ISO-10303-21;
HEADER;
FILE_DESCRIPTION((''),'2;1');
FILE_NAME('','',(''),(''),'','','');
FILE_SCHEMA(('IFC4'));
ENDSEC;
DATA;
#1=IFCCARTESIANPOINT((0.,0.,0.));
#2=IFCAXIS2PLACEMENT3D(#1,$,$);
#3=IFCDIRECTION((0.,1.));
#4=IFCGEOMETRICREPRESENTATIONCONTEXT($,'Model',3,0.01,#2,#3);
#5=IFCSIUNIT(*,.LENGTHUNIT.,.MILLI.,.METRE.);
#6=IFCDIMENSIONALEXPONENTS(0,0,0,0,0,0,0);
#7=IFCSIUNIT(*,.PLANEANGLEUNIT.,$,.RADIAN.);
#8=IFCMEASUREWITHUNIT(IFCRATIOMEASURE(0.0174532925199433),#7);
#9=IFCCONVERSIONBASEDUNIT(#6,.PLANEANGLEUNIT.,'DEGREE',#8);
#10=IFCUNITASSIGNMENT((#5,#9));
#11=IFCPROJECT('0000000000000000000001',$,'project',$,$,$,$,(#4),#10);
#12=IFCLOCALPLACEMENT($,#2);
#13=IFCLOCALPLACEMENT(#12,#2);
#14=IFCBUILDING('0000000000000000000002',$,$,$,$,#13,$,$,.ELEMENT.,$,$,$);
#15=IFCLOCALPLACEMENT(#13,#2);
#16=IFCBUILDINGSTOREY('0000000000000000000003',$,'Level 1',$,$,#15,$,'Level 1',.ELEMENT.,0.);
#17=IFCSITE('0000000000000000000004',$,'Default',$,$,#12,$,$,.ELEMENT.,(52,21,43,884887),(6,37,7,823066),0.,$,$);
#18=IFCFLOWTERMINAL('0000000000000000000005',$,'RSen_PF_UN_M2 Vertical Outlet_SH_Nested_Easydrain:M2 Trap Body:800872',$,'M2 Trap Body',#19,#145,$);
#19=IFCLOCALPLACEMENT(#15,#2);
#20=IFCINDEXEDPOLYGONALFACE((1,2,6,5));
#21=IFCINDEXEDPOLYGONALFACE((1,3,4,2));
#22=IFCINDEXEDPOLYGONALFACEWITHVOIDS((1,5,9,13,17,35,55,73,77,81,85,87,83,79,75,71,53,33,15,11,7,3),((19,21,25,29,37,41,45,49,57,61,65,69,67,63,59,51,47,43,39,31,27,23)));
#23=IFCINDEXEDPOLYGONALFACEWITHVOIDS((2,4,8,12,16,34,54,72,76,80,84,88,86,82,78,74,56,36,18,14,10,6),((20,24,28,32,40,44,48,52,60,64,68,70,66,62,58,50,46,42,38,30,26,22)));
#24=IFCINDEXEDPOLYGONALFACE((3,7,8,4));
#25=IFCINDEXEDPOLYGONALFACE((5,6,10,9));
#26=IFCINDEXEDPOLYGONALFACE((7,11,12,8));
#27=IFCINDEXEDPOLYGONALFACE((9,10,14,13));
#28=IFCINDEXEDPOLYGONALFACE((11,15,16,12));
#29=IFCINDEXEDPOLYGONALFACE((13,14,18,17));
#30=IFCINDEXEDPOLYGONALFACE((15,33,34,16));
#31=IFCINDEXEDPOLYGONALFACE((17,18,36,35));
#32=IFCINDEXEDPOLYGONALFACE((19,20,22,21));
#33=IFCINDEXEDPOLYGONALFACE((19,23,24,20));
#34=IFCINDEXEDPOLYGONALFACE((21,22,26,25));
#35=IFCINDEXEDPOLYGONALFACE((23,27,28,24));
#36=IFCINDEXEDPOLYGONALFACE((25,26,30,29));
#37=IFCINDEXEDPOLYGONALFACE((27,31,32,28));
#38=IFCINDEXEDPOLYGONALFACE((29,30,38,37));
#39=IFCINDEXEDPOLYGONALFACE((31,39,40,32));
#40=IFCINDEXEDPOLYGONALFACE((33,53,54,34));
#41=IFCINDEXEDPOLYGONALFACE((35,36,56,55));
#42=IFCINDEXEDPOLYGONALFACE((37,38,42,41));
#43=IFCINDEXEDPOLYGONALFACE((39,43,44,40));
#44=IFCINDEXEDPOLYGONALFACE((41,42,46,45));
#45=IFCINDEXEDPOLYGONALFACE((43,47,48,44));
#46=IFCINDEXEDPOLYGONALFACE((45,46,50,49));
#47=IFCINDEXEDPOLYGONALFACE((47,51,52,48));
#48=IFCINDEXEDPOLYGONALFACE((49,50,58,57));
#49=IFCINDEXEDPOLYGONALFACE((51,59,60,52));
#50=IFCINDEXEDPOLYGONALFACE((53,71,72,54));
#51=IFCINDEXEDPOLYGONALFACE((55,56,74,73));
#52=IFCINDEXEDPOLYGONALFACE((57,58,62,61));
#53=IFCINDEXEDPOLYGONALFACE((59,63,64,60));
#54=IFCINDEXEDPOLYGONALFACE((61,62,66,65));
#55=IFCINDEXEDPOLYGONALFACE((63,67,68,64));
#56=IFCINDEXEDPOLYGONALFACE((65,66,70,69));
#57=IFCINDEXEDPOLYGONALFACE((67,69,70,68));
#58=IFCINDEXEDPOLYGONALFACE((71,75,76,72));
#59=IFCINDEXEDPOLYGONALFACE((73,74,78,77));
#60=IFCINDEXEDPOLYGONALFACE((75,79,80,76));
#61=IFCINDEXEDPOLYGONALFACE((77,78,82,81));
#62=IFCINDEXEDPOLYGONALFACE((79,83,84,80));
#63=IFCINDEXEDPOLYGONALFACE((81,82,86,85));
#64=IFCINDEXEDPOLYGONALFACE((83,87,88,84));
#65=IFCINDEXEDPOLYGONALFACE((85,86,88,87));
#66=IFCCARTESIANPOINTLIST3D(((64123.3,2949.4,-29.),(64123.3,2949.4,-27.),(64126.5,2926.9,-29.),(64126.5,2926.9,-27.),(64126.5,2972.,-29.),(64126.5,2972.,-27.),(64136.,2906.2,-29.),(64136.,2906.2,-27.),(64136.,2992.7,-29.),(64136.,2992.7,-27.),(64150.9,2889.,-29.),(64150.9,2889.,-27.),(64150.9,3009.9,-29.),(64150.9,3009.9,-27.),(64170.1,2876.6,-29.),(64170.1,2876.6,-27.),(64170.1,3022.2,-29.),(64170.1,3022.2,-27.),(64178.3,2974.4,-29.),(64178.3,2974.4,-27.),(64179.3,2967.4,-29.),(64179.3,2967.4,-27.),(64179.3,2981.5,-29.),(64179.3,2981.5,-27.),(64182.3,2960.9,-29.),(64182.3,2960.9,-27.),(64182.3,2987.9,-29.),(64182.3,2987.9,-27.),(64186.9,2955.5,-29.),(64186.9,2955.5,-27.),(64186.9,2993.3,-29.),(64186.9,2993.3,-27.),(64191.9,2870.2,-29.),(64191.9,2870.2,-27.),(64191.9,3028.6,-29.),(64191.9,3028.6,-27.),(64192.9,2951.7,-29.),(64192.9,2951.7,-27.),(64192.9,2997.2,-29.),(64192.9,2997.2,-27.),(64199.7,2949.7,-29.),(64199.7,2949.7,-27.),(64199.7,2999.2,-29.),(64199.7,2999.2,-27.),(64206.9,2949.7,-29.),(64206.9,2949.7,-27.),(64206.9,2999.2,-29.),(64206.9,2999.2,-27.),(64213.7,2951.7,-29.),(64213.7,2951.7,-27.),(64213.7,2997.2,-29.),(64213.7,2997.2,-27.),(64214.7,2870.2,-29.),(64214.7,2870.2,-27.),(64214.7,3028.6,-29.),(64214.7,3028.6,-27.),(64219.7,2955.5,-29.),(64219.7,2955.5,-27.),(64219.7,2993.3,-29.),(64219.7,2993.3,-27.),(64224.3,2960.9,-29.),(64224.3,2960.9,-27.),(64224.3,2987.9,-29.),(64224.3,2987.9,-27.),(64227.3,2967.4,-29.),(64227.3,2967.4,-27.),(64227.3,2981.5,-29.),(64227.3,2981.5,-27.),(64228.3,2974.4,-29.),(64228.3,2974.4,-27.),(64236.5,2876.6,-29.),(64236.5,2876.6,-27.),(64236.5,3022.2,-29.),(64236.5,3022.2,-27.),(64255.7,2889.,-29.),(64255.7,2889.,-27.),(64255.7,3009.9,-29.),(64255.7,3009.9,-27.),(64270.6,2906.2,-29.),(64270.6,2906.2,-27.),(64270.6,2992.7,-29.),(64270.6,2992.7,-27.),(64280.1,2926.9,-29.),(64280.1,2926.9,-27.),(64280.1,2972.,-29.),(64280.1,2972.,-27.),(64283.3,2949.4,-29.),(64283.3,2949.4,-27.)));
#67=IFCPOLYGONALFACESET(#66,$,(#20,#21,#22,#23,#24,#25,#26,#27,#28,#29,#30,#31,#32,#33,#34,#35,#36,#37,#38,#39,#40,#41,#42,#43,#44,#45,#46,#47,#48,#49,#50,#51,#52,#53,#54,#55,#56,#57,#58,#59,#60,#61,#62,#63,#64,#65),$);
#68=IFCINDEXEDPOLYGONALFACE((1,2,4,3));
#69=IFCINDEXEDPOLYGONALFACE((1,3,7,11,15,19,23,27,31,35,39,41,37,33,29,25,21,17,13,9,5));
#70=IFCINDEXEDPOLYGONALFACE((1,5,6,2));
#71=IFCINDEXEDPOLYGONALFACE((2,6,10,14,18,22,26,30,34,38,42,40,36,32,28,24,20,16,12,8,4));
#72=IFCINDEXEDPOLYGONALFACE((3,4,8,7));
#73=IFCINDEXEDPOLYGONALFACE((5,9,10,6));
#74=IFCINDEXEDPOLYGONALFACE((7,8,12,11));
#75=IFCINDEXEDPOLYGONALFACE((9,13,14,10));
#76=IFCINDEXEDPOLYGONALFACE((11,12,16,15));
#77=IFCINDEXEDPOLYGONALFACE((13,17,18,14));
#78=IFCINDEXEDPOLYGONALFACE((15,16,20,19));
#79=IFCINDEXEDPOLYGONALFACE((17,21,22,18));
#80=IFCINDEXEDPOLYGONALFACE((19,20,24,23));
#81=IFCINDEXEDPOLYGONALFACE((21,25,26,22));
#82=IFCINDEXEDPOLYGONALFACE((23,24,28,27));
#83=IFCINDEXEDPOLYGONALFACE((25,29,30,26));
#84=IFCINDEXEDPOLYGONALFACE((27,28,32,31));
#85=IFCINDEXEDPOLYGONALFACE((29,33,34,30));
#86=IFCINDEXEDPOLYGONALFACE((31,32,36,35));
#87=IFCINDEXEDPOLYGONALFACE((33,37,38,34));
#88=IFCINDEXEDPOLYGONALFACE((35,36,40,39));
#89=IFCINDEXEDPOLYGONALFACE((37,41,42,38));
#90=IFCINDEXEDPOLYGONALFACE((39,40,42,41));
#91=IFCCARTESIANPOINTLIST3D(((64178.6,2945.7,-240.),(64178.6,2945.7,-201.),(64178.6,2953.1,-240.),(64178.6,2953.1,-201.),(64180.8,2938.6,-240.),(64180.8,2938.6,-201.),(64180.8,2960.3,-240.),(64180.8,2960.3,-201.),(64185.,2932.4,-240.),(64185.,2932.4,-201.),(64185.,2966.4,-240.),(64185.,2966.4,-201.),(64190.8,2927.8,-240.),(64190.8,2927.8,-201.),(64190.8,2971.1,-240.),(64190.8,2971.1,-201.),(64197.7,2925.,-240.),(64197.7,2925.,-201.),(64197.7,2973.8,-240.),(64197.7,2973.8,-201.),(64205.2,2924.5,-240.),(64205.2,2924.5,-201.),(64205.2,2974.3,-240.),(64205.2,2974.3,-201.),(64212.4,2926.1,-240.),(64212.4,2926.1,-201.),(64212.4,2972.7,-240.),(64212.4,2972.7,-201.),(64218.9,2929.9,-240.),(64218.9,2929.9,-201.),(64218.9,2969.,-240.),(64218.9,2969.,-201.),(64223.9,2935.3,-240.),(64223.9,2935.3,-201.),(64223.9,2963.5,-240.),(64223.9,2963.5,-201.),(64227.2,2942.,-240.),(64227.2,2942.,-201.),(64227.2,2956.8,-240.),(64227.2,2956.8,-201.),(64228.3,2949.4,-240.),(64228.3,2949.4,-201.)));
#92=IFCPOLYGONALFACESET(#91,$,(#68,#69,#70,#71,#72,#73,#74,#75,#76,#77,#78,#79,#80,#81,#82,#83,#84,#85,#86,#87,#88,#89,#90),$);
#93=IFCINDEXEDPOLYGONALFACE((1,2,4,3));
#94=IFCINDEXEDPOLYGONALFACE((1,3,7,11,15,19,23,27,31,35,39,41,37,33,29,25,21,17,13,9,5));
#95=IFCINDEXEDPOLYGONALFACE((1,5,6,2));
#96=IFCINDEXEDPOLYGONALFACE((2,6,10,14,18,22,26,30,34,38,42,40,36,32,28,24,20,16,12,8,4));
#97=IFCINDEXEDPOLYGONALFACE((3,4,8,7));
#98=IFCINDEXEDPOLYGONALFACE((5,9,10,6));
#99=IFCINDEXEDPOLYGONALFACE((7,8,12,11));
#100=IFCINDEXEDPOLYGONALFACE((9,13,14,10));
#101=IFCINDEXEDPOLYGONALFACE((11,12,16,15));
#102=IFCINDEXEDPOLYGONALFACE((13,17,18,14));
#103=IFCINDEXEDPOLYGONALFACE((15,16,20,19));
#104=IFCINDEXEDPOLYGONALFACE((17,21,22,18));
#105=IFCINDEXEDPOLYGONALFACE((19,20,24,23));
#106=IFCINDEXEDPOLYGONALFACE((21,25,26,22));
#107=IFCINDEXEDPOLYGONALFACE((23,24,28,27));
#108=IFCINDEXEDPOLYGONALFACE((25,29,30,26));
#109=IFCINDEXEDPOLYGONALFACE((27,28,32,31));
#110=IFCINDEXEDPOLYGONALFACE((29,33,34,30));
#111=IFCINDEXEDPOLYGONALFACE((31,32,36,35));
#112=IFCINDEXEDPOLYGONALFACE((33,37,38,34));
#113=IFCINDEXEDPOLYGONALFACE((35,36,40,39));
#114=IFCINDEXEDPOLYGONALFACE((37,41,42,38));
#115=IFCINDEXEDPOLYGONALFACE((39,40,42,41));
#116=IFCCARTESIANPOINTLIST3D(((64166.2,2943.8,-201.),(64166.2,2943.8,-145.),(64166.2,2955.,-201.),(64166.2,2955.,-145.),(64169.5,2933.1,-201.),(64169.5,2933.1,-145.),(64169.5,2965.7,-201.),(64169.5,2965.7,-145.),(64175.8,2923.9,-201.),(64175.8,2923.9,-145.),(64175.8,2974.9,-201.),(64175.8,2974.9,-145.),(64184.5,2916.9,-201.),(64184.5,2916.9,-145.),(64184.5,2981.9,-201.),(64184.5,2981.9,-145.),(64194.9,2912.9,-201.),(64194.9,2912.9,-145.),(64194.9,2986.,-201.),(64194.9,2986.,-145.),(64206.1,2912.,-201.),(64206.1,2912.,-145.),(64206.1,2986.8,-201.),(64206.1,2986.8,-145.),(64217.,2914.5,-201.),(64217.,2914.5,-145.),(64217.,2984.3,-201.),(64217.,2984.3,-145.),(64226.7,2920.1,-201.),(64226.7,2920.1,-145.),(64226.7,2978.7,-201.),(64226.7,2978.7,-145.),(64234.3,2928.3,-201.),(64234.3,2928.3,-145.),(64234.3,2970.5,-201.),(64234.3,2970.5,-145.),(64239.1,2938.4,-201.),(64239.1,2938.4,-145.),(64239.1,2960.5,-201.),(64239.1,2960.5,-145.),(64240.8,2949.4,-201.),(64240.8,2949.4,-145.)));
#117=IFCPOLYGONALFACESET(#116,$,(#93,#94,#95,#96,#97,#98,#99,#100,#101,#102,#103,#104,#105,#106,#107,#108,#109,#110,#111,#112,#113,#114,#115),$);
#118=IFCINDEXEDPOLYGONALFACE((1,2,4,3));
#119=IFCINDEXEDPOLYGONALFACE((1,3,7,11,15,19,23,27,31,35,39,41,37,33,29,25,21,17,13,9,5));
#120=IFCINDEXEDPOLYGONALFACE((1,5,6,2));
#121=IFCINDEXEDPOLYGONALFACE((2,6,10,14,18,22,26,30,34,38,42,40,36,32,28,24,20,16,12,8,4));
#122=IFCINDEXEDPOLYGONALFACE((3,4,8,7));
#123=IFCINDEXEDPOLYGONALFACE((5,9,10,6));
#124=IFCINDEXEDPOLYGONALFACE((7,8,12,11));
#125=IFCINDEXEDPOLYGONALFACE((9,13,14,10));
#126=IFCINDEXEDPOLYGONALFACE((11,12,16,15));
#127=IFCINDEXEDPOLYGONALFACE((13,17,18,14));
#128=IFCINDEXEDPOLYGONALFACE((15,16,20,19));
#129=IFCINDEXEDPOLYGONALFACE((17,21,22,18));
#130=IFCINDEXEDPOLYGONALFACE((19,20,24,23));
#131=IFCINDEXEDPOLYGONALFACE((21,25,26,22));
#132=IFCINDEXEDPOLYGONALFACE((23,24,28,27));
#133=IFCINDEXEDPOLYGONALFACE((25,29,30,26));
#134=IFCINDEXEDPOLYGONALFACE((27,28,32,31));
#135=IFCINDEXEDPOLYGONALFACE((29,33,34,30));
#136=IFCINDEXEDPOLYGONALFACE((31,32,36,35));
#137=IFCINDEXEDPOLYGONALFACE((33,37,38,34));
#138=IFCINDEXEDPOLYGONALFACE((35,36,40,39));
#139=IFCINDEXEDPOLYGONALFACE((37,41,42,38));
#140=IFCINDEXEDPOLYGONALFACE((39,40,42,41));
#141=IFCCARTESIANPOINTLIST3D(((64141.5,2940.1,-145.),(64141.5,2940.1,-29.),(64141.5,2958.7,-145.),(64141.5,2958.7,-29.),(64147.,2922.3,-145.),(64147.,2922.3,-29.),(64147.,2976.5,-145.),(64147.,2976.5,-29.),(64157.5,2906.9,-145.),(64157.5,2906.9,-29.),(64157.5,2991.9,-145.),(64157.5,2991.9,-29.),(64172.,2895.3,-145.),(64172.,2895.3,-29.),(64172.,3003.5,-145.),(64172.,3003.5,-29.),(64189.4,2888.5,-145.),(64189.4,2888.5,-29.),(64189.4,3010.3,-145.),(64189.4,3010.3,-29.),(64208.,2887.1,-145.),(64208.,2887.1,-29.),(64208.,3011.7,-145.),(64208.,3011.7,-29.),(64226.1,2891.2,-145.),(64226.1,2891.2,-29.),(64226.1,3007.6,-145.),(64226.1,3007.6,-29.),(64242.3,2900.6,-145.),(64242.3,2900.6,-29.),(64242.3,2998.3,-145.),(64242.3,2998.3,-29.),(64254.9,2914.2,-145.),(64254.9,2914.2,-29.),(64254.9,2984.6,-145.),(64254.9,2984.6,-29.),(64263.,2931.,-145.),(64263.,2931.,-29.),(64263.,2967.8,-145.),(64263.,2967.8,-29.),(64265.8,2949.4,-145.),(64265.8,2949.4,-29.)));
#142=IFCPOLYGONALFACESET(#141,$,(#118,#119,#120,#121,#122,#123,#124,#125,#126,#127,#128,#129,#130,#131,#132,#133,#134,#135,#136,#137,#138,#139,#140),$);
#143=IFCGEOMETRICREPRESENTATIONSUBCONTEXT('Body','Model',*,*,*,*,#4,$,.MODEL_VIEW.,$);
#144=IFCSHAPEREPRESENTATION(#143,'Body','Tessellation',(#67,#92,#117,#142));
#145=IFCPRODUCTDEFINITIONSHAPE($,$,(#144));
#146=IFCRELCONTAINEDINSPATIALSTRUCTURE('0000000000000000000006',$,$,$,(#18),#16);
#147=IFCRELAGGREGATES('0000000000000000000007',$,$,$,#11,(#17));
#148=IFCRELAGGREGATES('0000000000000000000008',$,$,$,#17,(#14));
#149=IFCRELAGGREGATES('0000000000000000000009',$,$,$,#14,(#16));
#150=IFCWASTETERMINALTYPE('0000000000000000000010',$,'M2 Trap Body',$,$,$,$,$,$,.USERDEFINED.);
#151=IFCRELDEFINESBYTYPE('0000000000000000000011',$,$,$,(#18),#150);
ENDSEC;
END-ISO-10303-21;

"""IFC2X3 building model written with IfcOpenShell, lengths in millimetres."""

from ifc_helpers import new_model, entity, si_unit, converted_unit, direction, frame, frame_2d, origin, origin_2d_with_axis, place, context, subcontext, project, spatial, circle_curve, parameter, trimmed, segment, composite_curve, circle, outline, extrude, source, transform, mapped, type_object, type_shapes, element, save


model = new_model("IFC2X3")

# Units and contexts
model_context = context("Model", 3, precision=0.01, world=origin(), true_north=direction((0.0, 1.0)))
body_context = subcontext(model_context, "Body", "Model", "MODEL_VIEW")
ifc_project = project(units=[si_unit("LENGTHUNIT", "METRE", prefix="MILLI"), converted_unit("PLANEANGLEUNIT", "DEGREE", entity("IfcRatioMeasure", 0.0174532925199433), si_unit("PLANEANGLEUNIT", "RADIAN"), dimensions=[0, 0, 0, 0, 0, 0, 0])], contexts=[model_context])

# Site, building, storey
site_placement = place(None, origin())
site = spatial("IfcSite", under=ifc_project, at=site_placement, Name="Default", CompositionType="ELEMENT", RefLatitude=(52, 21, 43, 884887), RefLongitude=(6, 37, 7, 823066), RefElevation=0.0)
building_placement = place(site_placement, origin())
building = spatial("IfcBuilding", under=site, at=building_placement, CompositionType="ELEMENT")
storey_placement = place(building_placement, origin())
storey = spatial("IfcBuildingStorey", under=building, at=storey_placement, Name="Level 1", LongName="Level 1", CompositionType="ELEMENT", Elevation=0.0)

# Flow terminal
waste_terminal_type_1 = type_object("IfcWasteTerminalType", Name="M2 Trap Body", PredefinedType="USERDEFINED")
shared_shape_1 = source(origin(), body_context, "Body", "SweptSolid", [
    extrude(outline(composite_curve([segment(trimmed(circle_curve(origin_2d_with_axis(), 80.0), [parameter(0.0)], [parameter(180.0)], True, "PARAMETER"), True, "CONTINUOUS"), segment(trimmed(circle_curve(origin_2d_with_axis(), 80.0), [parameter(180.0)], [parameter(360.0)], True, "PARAMETER"), True, "CONTINUOUS")], self_intersect=False), holes=[composite_curve([segment(trimmed(circle_curve(frame_2d((0.0, 25.0), x_axis=(1.0, 0.0)), 25.0), [parameter(180.0)], [parameter(360.0)], True, "PARAMETER"), False, "CONTINUOUS"), segment(trimmed(circle_curve(frame_2d((0.0, 25.0), x_axis=(1.0, 0.0)), 25.0), [parameter(0.0)], [parameter(180.0)], True, "PARAMETER"), False, "CONTINUOUS")], self_intersect=False)]), frame((0.0, -25.0, -2.0)), (0.0, 0.0, 1.0), 2.0),
    extrude(circle(Radius=25.0, at=frame_2d((0.0, 0.0), x_axis=(1.0, 0.0))), frame((0.0, -25.0, -213.0)), (0.0, 0.0, 1.0), 39.0),
    extrude(circle(Radius=37.5, at=frame_2d((0.0, 0.0), x_axis=(1.0, 0.0))), frame((0.0, -25.0, -174.0)), (0.0, 0.0, 1.0), 56.0),
    extrude(circle(Radius=62.5, at=frame_2d((0.0, 0.0), x_axis=(1.0, 0.0))), frame((0.0, -25.0, -118.0)), (0.0, 0.0, 1.0), 116.0),
])
type_shapes(waste_terminal_type_1, [shared_shape_1])
for number, where, name in (
    (1, (64203.3, 2974.4, -27.0), "RSen_PF_UN_M2 Vertical Outlet_SH_Nested_Easydrain:M2 Trap Body:800872"),
):
    element("IfcFlowTerminal", number, at=place(storey_placement, frame(where)), inside=storey, type_object=waste_terminal_type_1, Name=name, ObjectType="M2 Trap Body", context=body_context, shape_type="MappedRepresentation", body=[
        mapped(shared_shape_1, transform((0.0, 0.0, 0.0), scale=1.0)),
    ])

save(model, "model.ifc")
